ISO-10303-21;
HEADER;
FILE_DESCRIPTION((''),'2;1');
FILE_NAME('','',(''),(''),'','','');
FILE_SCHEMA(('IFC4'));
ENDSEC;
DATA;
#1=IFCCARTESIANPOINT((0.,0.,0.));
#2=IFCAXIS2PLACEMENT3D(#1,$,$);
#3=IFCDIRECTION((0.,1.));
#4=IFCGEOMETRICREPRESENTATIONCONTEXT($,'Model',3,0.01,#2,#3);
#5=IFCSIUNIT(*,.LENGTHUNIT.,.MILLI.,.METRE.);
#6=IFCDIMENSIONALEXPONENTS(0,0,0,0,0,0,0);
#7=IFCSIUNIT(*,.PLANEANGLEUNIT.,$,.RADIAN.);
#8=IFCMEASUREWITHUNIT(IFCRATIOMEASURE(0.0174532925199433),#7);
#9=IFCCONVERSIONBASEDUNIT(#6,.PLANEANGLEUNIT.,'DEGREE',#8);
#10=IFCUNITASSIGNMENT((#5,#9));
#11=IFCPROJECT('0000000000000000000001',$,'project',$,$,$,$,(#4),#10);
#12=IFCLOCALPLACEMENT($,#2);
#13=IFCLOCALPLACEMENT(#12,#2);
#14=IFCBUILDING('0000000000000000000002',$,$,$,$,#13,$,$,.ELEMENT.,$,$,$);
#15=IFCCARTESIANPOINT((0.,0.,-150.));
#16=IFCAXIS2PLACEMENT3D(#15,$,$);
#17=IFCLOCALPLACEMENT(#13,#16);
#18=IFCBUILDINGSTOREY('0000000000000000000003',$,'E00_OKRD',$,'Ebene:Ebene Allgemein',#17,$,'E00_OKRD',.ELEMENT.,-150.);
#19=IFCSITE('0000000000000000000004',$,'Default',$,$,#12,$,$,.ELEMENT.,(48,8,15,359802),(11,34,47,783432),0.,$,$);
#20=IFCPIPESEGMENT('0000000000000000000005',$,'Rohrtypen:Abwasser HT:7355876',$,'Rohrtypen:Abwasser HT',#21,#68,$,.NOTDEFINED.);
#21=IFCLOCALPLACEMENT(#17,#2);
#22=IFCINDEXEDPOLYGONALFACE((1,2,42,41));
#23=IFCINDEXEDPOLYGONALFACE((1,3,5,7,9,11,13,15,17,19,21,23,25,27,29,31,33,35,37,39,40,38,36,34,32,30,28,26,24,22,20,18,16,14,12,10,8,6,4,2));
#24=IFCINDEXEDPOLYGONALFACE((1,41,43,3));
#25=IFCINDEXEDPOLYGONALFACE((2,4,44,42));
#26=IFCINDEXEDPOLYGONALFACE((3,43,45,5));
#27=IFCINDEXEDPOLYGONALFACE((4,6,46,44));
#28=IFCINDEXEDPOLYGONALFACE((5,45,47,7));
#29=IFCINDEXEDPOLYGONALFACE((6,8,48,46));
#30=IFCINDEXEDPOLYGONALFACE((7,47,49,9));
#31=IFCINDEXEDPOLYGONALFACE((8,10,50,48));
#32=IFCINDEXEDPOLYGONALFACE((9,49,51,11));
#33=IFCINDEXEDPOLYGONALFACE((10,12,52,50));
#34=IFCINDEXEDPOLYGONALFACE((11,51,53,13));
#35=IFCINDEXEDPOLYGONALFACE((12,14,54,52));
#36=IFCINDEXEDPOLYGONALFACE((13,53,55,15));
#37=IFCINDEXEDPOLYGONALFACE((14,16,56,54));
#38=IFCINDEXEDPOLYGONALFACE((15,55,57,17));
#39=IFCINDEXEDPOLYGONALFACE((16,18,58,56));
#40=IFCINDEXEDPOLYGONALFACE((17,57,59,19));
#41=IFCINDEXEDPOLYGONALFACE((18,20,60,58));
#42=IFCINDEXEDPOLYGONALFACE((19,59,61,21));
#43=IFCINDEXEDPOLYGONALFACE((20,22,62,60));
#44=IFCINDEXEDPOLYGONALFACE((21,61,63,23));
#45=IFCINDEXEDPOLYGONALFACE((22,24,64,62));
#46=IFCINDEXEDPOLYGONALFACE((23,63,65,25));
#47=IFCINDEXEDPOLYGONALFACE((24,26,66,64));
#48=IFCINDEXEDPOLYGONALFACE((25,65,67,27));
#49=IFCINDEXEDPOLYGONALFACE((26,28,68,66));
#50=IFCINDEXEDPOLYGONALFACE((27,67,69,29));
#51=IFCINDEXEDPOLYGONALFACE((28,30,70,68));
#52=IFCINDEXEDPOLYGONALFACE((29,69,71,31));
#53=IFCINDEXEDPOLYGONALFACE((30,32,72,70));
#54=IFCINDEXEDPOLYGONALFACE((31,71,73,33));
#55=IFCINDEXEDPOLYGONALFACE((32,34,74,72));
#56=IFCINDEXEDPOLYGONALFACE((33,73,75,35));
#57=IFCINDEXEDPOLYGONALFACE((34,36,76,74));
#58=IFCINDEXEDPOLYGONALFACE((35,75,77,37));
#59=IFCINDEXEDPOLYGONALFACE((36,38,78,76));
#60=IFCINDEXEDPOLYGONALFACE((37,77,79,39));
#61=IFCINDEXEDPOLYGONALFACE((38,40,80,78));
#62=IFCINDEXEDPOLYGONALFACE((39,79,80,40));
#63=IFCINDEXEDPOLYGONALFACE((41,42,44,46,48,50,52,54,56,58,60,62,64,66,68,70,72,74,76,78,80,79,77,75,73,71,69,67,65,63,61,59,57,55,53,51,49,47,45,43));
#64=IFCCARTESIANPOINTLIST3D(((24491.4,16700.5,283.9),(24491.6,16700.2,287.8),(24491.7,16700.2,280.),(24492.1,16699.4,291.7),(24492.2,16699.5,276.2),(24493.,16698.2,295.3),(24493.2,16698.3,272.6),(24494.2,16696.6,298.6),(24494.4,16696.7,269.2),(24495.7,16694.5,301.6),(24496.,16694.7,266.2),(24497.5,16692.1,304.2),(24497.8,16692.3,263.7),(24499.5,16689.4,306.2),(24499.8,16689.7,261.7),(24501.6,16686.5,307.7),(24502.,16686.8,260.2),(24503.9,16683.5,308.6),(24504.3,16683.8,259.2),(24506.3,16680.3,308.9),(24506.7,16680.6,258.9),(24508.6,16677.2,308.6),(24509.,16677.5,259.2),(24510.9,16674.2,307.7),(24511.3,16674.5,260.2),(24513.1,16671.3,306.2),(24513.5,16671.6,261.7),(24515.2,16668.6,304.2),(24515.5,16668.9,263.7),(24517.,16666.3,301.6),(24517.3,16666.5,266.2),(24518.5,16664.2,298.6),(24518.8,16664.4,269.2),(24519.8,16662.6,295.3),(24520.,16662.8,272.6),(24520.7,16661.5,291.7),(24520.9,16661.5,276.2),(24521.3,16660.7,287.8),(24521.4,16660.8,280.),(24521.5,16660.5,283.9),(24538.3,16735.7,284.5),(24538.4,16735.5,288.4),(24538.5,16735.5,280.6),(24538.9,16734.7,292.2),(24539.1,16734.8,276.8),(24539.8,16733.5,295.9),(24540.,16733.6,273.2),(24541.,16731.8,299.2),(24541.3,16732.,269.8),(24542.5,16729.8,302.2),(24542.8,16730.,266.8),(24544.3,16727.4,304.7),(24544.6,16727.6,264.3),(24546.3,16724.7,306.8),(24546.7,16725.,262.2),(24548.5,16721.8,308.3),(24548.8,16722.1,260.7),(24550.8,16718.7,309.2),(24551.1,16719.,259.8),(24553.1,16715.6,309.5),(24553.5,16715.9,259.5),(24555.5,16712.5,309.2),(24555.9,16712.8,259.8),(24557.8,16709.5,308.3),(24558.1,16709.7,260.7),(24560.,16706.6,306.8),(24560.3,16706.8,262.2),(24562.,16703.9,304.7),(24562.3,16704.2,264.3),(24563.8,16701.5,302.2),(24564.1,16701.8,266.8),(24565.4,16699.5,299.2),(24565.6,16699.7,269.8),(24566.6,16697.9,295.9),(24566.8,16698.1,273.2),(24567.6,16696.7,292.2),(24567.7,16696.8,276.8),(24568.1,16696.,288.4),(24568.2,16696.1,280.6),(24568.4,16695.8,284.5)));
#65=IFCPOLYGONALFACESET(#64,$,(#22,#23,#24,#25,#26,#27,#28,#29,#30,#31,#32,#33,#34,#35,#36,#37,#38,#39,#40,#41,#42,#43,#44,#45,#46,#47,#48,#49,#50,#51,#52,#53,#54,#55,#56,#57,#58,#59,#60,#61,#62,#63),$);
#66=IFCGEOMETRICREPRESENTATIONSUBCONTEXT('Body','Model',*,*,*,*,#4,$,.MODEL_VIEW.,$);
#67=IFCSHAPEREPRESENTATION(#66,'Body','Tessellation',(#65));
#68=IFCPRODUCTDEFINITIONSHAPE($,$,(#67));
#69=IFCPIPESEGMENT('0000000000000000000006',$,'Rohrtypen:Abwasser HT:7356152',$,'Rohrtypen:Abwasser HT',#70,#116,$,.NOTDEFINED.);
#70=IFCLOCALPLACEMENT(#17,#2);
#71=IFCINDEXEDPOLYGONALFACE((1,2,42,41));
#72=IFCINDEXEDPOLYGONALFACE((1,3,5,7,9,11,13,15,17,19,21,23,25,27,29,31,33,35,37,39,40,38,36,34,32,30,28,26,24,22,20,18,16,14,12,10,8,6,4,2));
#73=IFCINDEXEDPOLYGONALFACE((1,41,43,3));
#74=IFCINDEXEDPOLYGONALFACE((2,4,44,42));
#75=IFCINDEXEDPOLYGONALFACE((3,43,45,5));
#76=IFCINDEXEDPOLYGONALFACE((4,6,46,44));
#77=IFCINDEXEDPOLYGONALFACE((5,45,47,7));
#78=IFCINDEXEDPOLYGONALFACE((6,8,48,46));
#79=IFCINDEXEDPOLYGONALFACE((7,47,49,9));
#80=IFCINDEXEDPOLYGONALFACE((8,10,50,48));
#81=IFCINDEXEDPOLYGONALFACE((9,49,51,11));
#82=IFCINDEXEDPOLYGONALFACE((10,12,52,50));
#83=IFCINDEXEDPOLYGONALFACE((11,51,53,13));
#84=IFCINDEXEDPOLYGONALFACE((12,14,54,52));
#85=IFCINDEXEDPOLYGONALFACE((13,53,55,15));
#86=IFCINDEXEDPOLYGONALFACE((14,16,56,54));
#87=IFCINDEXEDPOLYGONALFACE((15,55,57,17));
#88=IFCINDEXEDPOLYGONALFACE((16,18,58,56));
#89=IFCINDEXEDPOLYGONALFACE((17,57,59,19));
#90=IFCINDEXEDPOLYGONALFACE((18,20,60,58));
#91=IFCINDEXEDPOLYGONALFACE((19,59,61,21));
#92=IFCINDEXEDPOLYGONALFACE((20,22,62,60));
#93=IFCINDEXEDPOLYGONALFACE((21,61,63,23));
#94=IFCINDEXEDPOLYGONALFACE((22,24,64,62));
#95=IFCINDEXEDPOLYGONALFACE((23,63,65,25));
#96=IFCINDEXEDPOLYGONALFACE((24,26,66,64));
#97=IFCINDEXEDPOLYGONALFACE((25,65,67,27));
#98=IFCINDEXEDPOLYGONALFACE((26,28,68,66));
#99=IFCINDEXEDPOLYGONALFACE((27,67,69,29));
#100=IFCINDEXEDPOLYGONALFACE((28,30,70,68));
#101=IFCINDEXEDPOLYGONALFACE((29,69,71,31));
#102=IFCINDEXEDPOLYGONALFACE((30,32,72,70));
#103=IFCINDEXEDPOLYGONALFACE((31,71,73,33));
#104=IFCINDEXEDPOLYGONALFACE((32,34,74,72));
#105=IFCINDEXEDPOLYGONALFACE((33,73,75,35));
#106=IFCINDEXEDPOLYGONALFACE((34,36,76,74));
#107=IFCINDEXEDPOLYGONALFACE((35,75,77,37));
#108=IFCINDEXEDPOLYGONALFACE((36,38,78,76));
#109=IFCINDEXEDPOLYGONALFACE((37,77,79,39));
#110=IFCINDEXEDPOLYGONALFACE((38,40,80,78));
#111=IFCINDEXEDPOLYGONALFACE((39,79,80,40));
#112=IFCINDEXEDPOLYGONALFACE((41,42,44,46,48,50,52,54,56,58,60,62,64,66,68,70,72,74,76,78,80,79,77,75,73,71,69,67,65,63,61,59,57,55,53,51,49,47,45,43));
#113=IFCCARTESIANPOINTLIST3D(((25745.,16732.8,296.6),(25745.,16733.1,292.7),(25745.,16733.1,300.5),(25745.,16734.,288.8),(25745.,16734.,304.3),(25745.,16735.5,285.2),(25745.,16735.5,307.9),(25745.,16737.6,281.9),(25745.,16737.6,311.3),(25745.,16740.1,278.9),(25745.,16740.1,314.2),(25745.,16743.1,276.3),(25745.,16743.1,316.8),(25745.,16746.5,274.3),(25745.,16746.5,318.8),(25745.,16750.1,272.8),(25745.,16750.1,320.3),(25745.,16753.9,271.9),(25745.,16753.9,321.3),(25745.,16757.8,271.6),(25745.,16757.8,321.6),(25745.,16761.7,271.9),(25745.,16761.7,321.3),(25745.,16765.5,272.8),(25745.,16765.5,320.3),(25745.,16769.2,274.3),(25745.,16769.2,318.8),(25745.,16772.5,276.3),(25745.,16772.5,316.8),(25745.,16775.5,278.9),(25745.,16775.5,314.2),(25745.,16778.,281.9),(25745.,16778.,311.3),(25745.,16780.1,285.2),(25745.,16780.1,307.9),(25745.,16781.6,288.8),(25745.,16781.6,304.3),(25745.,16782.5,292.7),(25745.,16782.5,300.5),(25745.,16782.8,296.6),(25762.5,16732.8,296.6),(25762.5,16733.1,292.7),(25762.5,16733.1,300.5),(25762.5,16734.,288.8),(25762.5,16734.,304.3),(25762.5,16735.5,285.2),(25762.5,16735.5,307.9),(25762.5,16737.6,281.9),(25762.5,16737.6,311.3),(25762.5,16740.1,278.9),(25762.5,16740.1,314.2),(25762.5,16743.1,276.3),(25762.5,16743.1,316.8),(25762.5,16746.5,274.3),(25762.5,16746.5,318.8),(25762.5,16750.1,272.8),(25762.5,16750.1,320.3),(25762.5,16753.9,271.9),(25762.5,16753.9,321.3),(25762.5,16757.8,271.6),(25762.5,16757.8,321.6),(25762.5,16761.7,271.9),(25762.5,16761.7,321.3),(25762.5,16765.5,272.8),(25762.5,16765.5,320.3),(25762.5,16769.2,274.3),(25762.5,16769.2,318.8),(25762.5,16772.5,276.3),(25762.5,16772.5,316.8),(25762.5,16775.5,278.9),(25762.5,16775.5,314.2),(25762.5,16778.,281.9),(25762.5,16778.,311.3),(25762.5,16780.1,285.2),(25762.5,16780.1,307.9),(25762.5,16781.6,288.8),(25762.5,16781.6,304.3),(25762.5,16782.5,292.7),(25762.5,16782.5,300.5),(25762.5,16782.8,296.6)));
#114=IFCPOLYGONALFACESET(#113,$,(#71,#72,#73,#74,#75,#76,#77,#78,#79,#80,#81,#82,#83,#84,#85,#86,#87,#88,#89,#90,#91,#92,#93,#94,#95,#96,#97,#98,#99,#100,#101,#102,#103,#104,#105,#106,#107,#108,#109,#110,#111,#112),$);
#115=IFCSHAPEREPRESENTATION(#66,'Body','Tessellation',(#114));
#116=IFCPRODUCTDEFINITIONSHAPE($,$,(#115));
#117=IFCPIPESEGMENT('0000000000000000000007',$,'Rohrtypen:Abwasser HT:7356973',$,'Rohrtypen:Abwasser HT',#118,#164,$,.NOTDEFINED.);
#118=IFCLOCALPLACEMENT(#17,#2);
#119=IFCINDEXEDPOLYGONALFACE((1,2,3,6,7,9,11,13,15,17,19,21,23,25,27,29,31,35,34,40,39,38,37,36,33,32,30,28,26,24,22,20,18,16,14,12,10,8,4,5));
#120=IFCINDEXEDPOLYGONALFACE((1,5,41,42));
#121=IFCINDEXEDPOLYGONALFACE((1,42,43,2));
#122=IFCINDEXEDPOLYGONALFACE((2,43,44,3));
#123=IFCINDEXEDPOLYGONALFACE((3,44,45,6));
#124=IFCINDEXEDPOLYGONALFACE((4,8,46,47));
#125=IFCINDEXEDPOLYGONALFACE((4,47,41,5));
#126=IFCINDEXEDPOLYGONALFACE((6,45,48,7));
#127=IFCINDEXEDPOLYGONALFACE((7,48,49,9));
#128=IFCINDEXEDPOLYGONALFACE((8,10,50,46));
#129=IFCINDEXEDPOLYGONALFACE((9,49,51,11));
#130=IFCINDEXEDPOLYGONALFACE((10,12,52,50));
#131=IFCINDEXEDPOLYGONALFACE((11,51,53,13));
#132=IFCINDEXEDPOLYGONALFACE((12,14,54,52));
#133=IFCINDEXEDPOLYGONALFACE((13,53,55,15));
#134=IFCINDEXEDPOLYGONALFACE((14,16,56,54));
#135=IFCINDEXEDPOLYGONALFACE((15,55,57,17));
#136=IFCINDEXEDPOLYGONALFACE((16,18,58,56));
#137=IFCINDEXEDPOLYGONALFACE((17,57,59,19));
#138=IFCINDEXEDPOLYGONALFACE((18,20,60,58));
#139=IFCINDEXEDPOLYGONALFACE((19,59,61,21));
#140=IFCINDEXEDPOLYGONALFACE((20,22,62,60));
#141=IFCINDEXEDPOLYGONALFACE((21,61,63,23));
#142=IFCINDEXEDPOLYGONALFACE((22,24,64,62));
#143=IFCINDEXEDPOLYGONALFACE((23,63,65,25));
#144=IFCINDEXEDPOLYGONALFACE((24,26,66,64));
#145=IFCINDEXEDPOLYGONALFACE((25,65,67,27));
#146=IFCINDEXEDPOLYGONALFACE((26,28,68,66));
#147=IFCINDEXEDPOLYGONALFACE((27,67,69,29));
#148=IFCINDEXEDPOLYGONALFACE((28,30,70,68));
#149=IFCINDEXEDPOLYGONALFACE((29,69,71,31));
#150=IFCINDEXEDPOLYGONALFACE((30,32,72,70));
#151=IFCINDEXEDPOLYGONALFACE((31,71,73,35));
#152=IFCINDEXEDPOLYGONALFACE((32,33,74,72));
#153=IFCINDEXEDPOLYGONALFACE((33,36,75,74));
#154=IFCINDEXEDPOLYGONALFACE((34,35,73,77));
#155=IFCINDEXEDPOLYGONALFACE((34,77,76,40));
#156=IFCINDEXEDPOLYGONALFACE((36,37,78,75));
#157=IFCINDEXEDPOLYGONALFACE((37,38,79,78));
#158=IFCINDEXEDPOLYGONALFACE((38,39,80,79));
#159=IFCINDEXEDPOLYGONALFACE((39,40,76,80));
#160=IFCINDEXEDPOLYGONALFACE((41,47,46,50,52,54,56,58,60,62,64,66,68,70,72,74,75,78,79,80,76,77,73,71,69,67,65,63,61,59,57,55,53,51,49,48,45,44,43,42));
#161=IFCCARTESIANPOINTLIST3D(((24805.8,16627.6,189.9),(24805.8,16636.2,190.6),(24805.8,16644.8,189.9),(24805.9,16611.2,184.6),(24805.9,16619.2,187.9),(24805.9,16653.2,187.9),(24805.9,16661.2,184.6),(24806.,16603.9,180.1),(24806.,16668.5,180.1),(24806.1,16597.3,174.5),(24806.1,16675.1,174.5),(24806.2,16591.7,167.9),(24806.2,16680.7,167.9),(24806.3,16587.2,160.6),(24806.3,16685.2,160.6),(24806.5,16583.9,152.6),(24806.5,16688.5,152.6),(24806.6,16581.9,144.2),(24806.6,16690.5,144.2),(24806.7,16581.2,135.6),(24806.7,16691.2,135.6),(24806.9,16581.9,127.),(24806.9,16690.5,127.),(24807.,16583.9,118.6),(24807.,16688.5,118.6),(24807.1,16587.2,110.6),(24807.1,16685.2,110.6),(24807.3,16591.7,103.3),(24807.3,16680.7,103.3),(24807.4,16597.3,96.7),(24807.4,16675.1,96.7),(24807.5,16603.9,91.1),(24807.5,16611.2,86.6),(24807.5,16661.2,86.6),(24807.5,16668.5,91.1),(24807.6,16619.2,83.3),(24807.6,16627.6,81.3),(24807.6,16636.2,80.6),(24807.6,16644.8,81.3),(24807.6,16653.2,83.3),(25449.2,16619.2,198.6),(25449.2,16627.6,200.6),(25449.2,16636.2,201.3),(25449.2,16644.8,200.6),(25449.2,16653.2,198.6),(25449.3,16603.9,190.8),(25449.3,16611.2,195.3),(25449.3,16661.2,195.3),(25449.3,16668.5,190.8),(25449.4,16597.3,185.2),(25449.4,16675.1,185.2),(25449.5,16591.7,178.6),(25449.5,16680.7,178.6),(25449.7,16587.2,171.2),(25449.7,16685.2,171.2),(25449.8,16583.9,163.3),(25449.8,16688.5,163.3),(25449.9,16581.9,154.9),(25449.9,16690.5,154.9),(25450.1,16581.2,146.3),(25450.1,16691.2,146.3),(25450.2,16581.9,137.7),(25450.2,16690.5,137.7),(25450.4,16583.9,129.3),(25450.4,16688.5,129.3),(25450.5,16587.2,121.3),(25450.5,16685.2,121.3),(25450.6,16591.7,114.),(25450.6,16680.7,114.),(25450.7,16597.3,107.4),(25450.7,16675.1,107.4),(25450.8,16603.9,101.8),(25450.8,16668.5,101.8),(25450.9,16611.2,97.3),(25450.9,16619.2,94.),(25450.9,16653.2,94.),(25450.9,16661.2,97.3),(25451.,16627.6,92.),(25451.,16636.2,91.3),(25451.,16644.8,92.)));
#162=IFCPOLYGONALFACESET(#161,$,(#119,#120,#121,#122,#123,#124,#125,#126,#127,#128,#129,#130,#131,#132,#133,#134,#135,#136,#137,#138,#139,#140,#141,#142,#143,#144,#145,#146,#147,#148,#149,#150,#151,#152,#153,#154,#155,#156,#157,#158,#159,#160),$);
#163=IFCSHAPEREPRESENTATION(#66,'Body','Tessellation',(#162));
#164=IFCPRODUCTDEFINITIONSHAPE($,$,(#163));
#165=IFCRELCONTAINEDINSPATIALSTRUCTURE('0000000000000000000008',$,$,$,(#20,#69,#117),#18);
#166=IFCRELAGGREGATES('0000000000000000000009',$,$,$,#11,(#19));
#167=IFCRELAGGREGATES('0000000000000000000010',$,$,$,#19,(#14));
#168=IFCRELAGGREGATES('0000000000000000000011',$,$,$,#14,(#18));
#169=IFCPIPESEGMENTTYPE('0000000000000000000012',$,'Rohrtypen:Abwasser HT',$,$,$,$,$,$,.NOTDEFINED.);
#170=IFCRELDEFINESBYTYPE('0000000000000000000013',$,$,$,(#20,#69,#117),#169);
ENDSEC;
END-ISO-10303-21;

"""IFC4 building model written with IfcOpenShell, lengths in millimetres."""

from ifc_helpers import new_model, entity, si_unit, converted_unit, direction, frame, origin, place, context, subcontext, project, spatial, indexed_curve, outline, extrude, type_object, element, save


model = new_model("IFC4")

# Units and contexts
model_context = context("Model", 3, precision=0.01, world=origin(), true_north=direction((0.0, 1.0)))
body_context = subcontext(model_context, "Body", "Model", "MODEL_VIEW")
ifc_project = project(units=[si_unit("LENGTHUNIT", "METRE", prefix="MILLI"), converted_unit("PLANEANGLEUNIT", "DEGREE", entity("IfcRatioMeasure", 0.0174532925199433), si_unit("PLANEANGLEUNIT", "RADIAN"), dimensions=[0, 0, 0, 0, 0, 0, 0])], contexts=[model_context])

# Site, building, storey
site_placement = place(None, origin())
site = spatial("IfcSite", under=ifc_project, at=site_placement, Name="Default", CompositionType="ELEMENT", RefLatitude=(48, 8, 15, 359802), RefLongitude=(11, 34, 47, 783432), RefElevation=0.0)
building_placement = place(site_placement, origin())
building = spatial("IfcBuilding", under=site, at=building_placement, CompositionType="ELEMENT")
storey_placement = place(building_placement, frame((0.0, 0.0, -150.0)))
storey = spatial("IfcBuildingStorey", under=building, at=storey_placement, Name="E00_OKRD", ObjectType="Ebene:Ebene Allgemein", LongName="E00_OKRD", CompositionType="ELEMENT", Elevation=-150.0)

# Pipe segments
pipe_segment_type_1 = type_object("IfcPipeSegmentType", Name="Rohrtypen:Abwasser HT", PredefinedType="NOTDEFINED")
pipe_segment_1_placement = place(storey_placement, origin())
element("IfcPipeSegment", 1, at=pipe_segment_1_placement, inside=storey, type_object=pipe_segment_type_1, Name="Rohrtypen:Abwasser HT:7355876", ObjectType="Rohrtypen:Abwasser HT", PredefinedType="NOTDEFINED", context=body_context, shape_type="SweptSolid", body=[
    extrude(outline(indexed_curve([(25.0, 0.0), (24.7, 3.9), (23.8, 7.7), (22.3, 11.3), (20.2, 14.7), (17.7, 17.7), (14.7, 20.2), (11.3, 22.3), (7.7, 23.8), (3.9, 24.7), (0.0, 25.0), (-3.9, 24.7), (-7.7, 23.8), (-11.3, 22.3), (-14.7, 20.2), (-17.7, 17.7), (-20.2, 14.7), (-22.3, 11.3), (-23.8, 7.7), (-24.7, 3.9), (-25.0, 0.0), (-24.7, -3.9), (-23.8, -7.7), (-22.3, -11.3), (-20.2, -14.7), (-17.7, -17.7), (-14.7, -20.2), (-11.3, -22.3), (-7.7, -23.8), (-3.9, -24.7), (0.0, -25.0), (3.9, -24.7), (7.7, -23.8), (11.3, -22.3), (14.7, -20.2), (17.7, -17.7), (20.2, -14.7), (22.3, -11.3), (23.8, -7.7), (24.7, -3.9), (25.0, 0.0)], self_intersect=False)), frame((24506.5, 16680.5, 283.9), z_axis=(0.798581, 0.601804, 0.01), x_axis=(0.601834, -0.798621, 0.0)), (0.0, 0.0, 1.0), 58.6),
])
pipe_segment_2_placement = place(storey_placement, origin())
element("IfcPipeSegment", 2, at=pipe_segment_2_placement, inside=storey, type_object=pipe_segment_type_1, Name="Rohrtypen:Abwasser HT:7356152", ObjectType="Rohrtypen:Abwasser HT", PredefinedType="NOTDEFINED", context=body_context, shape_type="SweptSolid", body=[
    extrude(outline(indexed_curve([(25.0, 0.0), (24.7, 3.9), (23.8, 7.7), (22.3, 11.3), (20.2, 14.7), (17.7, 17.7), (14.7, 20.2), (11.3, 22.3), (7.7, 23.8), (3.9, 24.7), (0.0, 25.0), (-3.9, 24.7), (-7.7, 23.8), (-11.3, 22.3), (-14.7, 20.2), (-17.7, 17.7), (-20.2, 14.7), (-22.3, 11.3), (-23.8, 7.7), (-24.7, 3.9), (-25.0, 0.0), (-24.7, -3.9), (-23.8, -7.7), (-22.3, -11.3), (-20.2, -14.7), (-17.7, -17.7), (-14.7, -20.2), (-11.3, -22.3), (-7.7, -23.8), (-3.9, -24.7), (0.0, -25.0), (3.9, -24.7), (7.7, -23.8), (11.3, -22.3), (14.7, -20.2), (17.7, -17.7), (20.2, -14.7), (22.3, -11.3), (23.8, -7.7), (24.7, -3.9), (25.0, 0.0)], self_intersect=False)), frame((25745.0, 16757.8, 296.6), z_axis=(1.0, 0.0, 0.0), x_axis=(0.0, -1.0, 0.0)), (0.0, 0.0, 1.0), 17.5),
])
pipe_segment_3_placement = place(storey_placement, origin())
element("IfcPipeSegment", 3, at=pipe_segment_3_placement, inside=storey, type_object=pipe_segment_type_1, Name="Rohrtypen:Abwasser HT:7356973", ObjectType="Rohrtypen:Abwasser HT", PredefinedType="NOTDEFINED", context=body_context, shape_type="SweptSolid", body=[
    extrude(outline(indexed_curve([(55.0, 0.0), (54.3, 8.6), (52.3, 17.0), (49.0, 25.0), (44.5, 32.3), (38.9, 38.9), (32.3, 44.5), (25.0, 49.0), (17.0, 52.3), (8.6, 54.3), (0.0, 55.0), (-8.6, 54.3), (-17.0, 52.3), (-25.0, 49.0), (-32.3, 44.5), (-38.9, 38.9), (-44.5, 32.3), (-49.0, 25.0), (-52.3, 17.0), (-54.3, 8.6), (-55.0, 0.0), (-54.3, -8.6), (-52.3, -17.0), (-49.0, -25.0), (-44.5, -32.3), (-38.9, -38.9), (-32.3, -44.5), (-25.0, -49.0), (-17.0, -52.3), (-8.6, -54.3), (0.0, -55.0), (8.6, -54.3), (17.0, -52.3), (25.0, -49.0), (32.3, -44.5), (38.9, -38.9), (44.5, -32.3), (49.0, -25.0), (52.3, -17.0), (54.3, -8.6), (55.0, 0.0)], self_intersect=False)), frame((24806.7, 16636.2, 135.6), z_axis=(0.999862, 0.0, 0.016604), x_axis=(0.0, -1.0, 0.0)), (0.0, 0.0, 1.0), 643.4),
])

save(model, "model.ifc")
